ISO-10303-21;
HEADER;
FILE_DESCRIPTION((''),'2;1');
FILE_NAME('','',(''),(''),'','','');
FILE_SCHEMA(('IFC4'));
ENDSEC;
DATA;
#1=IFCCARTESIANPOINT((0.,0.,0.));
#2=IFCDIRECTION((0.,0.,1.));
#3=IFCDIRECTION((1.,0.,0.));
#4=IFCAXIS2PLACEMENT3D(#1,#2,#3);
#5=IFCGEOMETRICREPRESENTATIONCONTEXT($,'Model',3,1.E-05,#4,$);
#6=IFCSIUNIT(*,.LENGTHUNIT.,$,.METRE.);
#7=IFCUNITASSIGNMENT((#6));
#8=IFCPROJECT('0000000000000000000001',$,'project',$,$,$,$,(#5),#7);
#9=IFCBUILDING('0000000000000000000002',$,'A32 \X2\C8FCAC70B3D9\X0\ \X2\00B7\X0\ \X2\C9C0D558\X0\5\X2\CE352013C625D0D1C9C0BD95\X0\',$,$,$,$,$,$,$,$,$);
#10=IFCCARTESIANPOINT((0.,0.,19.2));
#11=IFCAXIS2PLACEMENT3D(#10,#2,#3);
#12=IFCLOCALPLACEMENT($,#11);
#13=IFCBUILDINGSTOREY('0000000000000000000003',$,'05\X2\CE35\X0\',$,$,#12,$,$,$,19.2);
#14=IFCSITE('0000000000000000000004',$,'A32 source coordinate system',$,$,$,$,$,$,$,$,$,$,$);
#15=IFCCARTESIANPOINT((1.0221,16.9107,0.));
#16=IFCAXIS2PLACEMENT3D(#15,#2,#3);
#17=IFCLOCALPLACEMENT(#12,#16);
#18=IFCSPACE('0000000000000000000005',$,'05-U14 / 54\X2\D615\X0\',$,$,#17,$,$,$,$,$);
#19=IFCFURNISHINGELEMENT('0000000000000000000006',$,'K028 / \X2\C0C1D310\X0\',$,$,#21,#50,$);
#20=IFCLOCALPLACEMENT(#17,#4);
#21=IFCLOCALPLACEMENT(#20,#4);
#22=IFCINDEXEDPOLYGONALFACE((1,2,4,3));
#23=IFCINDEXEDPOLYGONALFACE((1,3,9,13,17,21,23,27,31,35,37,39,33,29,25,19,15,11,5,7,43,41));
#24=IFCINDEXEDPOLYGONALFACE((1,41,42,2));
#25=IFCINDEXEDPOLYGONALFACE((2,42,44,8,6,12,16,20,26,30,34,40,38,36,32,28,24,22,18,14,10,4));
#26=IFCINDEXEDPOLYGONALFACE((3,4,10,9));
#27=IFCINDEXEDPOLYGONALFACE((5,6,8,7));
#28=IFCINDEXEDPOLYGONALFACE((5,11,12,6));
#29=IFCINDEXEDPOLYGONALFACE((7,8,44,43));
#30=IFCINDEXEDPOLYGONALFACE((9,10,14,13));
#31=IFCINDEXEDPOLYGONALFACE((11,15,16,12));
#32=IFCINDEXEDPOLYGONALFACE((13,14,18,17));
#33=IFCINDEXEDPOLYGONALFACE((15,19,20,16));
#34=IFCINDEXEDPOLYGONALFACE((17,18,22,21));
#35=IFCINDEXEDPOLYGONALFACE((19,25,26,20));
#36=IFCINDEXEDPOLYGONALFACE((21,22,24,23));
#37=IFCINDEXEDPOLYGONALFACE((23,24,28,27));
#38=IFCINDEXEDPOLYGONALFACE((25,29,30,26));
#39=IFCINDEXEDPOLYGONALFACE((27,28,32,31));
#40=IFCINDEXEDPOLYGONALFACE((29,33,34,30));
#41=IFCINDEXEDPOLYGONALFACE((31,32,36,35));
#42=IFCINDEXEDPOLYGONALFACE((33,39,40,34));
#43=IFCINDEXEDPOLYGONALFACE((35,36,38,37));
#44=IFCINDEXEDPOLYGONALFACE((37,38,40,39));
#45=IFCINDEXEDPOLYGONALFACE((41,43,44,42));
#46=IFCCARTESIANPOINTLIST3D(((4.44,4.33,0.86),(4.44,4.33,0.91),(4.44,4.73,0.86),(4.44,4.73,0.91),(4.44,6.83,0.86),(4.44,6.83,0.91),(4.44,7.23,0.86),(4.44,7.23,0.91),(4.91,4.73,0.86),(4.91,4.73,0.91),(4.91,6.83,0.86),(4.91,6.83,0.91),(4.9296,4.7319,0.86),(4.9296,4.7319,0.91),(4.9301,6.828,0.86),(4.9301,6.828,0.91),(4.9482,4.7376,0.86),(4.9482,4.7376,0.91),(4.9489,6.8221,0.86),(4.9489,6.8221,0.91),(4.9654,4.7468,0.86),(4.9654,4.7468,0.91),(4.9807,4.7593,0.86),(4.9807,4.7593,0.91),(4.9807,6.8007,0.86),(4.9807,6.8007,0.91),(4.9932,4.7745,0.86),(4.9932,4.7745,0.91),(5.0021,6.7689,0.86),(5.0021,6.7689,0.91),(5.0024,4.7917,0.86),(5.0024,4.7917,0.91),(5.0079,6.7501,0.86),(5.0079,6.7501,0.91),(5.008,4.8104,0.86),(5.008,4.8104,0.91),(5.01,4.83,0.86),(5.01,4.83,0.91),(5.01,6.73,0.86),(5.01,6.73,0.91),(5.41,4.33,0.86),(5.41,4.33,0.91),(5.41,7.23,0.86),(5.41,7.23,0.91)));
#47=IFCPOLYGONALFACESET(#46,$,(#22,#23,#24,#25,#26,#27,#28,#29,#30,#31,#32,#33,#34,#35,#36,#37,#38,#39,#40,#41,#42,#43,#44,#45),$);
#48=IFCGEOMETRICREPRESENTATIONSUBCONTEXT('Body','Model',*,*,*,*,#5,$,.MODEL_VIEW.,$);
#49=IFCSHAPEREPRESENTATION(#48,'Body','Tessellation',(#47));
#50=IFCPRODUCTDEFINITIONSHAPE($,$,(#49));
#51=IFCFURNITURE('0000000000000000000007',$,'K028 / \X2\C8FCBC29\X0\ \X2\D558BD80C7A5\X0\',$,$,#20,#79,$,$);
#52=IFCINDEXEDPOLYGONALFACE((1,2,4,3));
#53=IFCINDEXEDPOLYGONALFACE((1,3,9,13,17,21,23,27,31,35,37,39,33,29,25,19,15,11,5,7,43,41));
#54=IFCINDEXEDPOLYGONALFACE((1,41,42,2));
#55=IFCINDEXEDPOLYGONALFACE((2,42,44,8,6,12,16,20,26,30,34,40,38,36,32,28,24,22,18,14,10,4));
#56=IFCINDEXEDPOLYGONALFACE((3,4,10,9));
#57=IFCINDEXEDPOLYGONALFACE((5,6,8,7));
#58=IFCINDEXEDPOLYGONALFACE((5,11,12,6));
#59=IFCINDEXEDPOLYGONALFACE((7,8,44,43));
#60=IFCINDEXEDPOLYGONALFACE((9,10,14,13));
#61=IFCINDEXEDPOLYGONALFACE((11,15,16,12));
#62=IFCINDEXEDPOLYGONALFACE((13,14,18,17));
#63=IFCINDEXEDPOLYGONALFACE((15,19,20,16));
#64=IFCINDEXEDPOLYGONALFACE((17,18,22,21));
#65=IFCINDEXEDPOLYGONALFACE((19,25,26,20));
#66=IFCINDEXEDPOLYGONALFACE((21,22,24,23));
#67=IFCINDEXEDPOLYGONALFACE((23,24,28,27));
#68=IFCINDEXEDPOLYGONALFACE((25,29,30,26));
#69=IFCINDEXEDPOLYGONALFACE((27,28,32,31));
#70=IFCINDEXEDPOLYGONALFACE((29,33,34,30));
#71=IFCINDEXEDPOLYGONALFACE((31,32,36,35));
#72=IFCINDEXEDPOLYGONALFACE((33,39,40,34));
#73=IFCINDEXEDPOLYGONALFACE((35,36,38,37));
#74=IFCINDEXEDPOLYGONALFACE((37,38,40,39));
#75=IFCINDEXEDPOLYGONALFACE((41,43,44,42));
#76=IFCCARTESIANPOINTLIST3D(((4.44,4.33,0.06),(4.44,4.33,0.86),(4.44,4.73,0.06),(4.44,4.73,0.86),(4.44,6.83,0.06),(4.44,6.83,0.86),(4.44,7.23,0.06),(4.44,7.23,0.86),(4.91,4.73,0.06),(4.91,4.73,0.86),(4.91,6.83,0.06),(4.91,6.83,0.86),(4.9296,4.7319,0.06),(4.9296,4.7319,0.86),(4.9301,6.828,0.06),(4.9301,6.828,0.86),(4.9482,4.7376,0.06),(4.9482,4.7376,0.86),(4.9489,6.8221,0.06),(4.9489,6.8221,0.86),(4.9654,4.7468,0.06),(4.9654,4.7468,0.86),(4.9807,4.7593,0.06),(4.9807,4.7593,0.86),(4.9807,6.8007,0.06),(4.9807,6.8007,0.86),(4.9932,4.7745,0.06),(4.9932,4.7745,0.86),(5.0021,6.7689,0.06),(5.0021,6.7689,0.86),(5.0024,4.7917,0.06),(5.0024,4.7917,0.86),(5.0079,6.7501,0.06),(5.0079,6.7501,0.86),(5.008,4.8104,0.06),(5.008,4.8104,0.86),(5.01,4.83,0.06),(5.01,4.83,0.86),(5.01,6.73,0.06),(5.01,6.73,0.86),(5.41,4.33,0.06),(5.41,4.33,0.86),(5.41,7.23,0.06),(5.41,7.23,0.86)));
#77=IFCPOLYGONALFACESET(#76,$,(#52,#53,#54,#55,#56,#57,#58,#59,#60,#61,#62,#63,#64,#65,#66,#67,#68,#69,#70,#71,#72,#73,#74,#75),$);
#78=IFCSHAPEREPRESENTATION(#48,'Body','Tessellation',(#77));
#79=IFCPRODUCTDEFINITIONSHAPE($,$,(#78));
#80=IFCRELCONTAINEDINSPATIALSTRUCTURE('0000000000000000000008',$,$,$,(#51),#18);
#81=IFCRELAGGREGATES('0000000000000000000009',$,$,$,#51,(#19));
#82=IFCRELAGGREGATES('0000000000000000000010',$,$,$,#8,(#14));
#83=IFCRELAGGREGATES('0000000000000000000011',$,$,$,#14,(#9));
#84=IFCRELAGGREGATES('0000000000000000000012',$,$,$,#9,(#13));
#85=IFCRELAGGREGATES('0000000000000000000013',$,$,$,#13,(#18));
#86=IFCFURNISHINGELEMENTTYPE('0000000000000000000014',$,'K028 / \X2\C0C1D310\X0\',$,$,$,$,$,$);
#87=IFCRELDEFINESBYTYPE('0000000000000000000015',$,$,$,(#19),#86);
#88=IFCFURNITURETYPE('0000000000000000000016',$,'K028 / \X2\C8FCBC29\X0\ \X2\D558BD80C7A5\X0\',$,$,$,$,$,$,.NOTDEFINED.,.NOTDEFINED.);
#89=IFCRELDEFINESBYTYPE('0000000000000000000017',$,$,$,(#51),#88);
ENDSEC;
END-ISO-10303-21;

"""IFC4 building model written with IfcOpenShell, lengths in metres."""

from ifc_helpers import new_model, si_unit, frame, origin, origin_with_axes, place, context, subcontext, project, spatial, polyline, outline, extrude, source, transform, mapped, type_object, type_shapes, element, aggregate, save


model = new_model("IFC4")

# Units and contexts
model_context = context("Model", 3, precision=1e-05, world=origin_with_axes())
body_context = subcontext(model_context, "Body", "Model", "MODEL_VIEW")
ifc_project = project(units=[si_unit("LENGTHUNIT", "METRE")], contexts=[model_context])

# Site, building, storey, space
site = spatial("IfcSite", under=ifc_project, Name="A32 source coordinate system")
building = spatial("IfcBuilding", under=site, Name="A32 주거동 · 지하5층–옥탑지붕")
storey_placement = place(None, frame((0.0, 0.0, 19.2), z_axis=(0.0, 0.0, 1.0), x_axis=(1.0, 0.0, 0.0)))
storey = spatial("IfcBuildingStorey", under=building, at=storey_placement, Name="05층", Elevation=19.2)
space_placement = place(storey_placement, frame((1.0221, 16.9107, 0.0), z_axis=(0.0, 0.0, 1.0), x_axis=(1.0, 0.0, 0.0)))
space = spatial("IfcSpace", under=storey, at=space_placement, Name="05-U14 / 54형")

# Furnishing element
furnishing_element_type_1 = type_object("IfcFurnishingElementType", Name="K028 / 상판")
shared_shape_1 = source(origin(), body_context, "Body", "SweptSolid", [
    extrude(outline(polyline([(5.41, 4.33), (4.44, 4.33), (4.44, 4.73), (4.91, 4.73), (4.9296, 4.7319), (4.9482, 4.7376), (4.9654, 4.7468), (4.9807, 4.7593), (4.9932, 4.7745), (5.0024, 4.7917), (5.008, 4.8104), (5.01, 4.83), (5.01, 6.73), (5.0079, 6.7501), (5.0021, 6.7689), (4.9807, 6.8007), (4.9489, 6.8221), (4.9301, 6.828), (4.91, 6.83), (4.44, 6.83), (4.44, 7.23), (5.41, 7.23), (5.41, 4.33)])), frame((0.0, 0.0, 0.86)), (0.0, 0.0, 1.0), 0.05),
])
type_shapes(furnishing_element_type_1, [shared_shape_1])
furniture_1_placement = place(space_placement, origin_with_axes())
furnishing_1_placement = place(furniture_1_placement, origin_with_axes())
furnishing_1 = element("IfcFurnishingElement", 1, at=furnishing_1_placement, type_object=furnishing_element_type_1, Name="K028 / 상판", context=body_context, shape_type="MappedRepresentation", body=[
    mapped(shared_shape_1, transform((0.0, 0.0, 0.0), scale=1.0)),
])

# Furniture
furniture_type_1 = type_object("IfcFurnitureType", Name="K028 / 주방 하부장", AssemblyPlace="NOTDEFINED", PredefinedType="NOTDEFINED")
shared_shape_2 = source(origin(), body_context, "Body", "SweptSolid", [
    extrude(outline(polyline([(5.41, 7.23), (5.41, 4.33), (4.44, 4.33), (4.44, 4.73), (4.91, 4.73), (4.9296, 4.7319), (4.9482, 4.7376), (4.9654, 4.7468), (4.9807, 4.7593), (4.9932, 4.7745), (5.0024, 4.7917), (5.008, 4.8104), (5.01, 4.83), (5.01, 6.73), (5.0079, 6.7501), (5.0021, 6.7689), (4.9807, 6.8007), (4.9489, 6.8221), (4.9301, 6.828), (4.91, 6.83), (4.44, 6.83), (4.44, 7.23), (5.41, 7.23)])), frame((0.0, 0.0, 0.06)), (0.0, 0.0, 1.0), 0.8),
])
type_shapes(furniture_type_1, [shared_shape_2])
furniture_1 = element("IfcFurniture", 2, at=furniture_1_placement, inside=space, type_object=furniture_type_1, Name="K028 / 주방 하부장", context=body_context, shape_type="MappedRepresentation", body=[
    mapped(shared_shape_2, transform((0.0, 0.0, 0.0), scale=1.0)),
])
aggregate(furniture_1, [furnishing_1])

save(model, "model.ifc")
